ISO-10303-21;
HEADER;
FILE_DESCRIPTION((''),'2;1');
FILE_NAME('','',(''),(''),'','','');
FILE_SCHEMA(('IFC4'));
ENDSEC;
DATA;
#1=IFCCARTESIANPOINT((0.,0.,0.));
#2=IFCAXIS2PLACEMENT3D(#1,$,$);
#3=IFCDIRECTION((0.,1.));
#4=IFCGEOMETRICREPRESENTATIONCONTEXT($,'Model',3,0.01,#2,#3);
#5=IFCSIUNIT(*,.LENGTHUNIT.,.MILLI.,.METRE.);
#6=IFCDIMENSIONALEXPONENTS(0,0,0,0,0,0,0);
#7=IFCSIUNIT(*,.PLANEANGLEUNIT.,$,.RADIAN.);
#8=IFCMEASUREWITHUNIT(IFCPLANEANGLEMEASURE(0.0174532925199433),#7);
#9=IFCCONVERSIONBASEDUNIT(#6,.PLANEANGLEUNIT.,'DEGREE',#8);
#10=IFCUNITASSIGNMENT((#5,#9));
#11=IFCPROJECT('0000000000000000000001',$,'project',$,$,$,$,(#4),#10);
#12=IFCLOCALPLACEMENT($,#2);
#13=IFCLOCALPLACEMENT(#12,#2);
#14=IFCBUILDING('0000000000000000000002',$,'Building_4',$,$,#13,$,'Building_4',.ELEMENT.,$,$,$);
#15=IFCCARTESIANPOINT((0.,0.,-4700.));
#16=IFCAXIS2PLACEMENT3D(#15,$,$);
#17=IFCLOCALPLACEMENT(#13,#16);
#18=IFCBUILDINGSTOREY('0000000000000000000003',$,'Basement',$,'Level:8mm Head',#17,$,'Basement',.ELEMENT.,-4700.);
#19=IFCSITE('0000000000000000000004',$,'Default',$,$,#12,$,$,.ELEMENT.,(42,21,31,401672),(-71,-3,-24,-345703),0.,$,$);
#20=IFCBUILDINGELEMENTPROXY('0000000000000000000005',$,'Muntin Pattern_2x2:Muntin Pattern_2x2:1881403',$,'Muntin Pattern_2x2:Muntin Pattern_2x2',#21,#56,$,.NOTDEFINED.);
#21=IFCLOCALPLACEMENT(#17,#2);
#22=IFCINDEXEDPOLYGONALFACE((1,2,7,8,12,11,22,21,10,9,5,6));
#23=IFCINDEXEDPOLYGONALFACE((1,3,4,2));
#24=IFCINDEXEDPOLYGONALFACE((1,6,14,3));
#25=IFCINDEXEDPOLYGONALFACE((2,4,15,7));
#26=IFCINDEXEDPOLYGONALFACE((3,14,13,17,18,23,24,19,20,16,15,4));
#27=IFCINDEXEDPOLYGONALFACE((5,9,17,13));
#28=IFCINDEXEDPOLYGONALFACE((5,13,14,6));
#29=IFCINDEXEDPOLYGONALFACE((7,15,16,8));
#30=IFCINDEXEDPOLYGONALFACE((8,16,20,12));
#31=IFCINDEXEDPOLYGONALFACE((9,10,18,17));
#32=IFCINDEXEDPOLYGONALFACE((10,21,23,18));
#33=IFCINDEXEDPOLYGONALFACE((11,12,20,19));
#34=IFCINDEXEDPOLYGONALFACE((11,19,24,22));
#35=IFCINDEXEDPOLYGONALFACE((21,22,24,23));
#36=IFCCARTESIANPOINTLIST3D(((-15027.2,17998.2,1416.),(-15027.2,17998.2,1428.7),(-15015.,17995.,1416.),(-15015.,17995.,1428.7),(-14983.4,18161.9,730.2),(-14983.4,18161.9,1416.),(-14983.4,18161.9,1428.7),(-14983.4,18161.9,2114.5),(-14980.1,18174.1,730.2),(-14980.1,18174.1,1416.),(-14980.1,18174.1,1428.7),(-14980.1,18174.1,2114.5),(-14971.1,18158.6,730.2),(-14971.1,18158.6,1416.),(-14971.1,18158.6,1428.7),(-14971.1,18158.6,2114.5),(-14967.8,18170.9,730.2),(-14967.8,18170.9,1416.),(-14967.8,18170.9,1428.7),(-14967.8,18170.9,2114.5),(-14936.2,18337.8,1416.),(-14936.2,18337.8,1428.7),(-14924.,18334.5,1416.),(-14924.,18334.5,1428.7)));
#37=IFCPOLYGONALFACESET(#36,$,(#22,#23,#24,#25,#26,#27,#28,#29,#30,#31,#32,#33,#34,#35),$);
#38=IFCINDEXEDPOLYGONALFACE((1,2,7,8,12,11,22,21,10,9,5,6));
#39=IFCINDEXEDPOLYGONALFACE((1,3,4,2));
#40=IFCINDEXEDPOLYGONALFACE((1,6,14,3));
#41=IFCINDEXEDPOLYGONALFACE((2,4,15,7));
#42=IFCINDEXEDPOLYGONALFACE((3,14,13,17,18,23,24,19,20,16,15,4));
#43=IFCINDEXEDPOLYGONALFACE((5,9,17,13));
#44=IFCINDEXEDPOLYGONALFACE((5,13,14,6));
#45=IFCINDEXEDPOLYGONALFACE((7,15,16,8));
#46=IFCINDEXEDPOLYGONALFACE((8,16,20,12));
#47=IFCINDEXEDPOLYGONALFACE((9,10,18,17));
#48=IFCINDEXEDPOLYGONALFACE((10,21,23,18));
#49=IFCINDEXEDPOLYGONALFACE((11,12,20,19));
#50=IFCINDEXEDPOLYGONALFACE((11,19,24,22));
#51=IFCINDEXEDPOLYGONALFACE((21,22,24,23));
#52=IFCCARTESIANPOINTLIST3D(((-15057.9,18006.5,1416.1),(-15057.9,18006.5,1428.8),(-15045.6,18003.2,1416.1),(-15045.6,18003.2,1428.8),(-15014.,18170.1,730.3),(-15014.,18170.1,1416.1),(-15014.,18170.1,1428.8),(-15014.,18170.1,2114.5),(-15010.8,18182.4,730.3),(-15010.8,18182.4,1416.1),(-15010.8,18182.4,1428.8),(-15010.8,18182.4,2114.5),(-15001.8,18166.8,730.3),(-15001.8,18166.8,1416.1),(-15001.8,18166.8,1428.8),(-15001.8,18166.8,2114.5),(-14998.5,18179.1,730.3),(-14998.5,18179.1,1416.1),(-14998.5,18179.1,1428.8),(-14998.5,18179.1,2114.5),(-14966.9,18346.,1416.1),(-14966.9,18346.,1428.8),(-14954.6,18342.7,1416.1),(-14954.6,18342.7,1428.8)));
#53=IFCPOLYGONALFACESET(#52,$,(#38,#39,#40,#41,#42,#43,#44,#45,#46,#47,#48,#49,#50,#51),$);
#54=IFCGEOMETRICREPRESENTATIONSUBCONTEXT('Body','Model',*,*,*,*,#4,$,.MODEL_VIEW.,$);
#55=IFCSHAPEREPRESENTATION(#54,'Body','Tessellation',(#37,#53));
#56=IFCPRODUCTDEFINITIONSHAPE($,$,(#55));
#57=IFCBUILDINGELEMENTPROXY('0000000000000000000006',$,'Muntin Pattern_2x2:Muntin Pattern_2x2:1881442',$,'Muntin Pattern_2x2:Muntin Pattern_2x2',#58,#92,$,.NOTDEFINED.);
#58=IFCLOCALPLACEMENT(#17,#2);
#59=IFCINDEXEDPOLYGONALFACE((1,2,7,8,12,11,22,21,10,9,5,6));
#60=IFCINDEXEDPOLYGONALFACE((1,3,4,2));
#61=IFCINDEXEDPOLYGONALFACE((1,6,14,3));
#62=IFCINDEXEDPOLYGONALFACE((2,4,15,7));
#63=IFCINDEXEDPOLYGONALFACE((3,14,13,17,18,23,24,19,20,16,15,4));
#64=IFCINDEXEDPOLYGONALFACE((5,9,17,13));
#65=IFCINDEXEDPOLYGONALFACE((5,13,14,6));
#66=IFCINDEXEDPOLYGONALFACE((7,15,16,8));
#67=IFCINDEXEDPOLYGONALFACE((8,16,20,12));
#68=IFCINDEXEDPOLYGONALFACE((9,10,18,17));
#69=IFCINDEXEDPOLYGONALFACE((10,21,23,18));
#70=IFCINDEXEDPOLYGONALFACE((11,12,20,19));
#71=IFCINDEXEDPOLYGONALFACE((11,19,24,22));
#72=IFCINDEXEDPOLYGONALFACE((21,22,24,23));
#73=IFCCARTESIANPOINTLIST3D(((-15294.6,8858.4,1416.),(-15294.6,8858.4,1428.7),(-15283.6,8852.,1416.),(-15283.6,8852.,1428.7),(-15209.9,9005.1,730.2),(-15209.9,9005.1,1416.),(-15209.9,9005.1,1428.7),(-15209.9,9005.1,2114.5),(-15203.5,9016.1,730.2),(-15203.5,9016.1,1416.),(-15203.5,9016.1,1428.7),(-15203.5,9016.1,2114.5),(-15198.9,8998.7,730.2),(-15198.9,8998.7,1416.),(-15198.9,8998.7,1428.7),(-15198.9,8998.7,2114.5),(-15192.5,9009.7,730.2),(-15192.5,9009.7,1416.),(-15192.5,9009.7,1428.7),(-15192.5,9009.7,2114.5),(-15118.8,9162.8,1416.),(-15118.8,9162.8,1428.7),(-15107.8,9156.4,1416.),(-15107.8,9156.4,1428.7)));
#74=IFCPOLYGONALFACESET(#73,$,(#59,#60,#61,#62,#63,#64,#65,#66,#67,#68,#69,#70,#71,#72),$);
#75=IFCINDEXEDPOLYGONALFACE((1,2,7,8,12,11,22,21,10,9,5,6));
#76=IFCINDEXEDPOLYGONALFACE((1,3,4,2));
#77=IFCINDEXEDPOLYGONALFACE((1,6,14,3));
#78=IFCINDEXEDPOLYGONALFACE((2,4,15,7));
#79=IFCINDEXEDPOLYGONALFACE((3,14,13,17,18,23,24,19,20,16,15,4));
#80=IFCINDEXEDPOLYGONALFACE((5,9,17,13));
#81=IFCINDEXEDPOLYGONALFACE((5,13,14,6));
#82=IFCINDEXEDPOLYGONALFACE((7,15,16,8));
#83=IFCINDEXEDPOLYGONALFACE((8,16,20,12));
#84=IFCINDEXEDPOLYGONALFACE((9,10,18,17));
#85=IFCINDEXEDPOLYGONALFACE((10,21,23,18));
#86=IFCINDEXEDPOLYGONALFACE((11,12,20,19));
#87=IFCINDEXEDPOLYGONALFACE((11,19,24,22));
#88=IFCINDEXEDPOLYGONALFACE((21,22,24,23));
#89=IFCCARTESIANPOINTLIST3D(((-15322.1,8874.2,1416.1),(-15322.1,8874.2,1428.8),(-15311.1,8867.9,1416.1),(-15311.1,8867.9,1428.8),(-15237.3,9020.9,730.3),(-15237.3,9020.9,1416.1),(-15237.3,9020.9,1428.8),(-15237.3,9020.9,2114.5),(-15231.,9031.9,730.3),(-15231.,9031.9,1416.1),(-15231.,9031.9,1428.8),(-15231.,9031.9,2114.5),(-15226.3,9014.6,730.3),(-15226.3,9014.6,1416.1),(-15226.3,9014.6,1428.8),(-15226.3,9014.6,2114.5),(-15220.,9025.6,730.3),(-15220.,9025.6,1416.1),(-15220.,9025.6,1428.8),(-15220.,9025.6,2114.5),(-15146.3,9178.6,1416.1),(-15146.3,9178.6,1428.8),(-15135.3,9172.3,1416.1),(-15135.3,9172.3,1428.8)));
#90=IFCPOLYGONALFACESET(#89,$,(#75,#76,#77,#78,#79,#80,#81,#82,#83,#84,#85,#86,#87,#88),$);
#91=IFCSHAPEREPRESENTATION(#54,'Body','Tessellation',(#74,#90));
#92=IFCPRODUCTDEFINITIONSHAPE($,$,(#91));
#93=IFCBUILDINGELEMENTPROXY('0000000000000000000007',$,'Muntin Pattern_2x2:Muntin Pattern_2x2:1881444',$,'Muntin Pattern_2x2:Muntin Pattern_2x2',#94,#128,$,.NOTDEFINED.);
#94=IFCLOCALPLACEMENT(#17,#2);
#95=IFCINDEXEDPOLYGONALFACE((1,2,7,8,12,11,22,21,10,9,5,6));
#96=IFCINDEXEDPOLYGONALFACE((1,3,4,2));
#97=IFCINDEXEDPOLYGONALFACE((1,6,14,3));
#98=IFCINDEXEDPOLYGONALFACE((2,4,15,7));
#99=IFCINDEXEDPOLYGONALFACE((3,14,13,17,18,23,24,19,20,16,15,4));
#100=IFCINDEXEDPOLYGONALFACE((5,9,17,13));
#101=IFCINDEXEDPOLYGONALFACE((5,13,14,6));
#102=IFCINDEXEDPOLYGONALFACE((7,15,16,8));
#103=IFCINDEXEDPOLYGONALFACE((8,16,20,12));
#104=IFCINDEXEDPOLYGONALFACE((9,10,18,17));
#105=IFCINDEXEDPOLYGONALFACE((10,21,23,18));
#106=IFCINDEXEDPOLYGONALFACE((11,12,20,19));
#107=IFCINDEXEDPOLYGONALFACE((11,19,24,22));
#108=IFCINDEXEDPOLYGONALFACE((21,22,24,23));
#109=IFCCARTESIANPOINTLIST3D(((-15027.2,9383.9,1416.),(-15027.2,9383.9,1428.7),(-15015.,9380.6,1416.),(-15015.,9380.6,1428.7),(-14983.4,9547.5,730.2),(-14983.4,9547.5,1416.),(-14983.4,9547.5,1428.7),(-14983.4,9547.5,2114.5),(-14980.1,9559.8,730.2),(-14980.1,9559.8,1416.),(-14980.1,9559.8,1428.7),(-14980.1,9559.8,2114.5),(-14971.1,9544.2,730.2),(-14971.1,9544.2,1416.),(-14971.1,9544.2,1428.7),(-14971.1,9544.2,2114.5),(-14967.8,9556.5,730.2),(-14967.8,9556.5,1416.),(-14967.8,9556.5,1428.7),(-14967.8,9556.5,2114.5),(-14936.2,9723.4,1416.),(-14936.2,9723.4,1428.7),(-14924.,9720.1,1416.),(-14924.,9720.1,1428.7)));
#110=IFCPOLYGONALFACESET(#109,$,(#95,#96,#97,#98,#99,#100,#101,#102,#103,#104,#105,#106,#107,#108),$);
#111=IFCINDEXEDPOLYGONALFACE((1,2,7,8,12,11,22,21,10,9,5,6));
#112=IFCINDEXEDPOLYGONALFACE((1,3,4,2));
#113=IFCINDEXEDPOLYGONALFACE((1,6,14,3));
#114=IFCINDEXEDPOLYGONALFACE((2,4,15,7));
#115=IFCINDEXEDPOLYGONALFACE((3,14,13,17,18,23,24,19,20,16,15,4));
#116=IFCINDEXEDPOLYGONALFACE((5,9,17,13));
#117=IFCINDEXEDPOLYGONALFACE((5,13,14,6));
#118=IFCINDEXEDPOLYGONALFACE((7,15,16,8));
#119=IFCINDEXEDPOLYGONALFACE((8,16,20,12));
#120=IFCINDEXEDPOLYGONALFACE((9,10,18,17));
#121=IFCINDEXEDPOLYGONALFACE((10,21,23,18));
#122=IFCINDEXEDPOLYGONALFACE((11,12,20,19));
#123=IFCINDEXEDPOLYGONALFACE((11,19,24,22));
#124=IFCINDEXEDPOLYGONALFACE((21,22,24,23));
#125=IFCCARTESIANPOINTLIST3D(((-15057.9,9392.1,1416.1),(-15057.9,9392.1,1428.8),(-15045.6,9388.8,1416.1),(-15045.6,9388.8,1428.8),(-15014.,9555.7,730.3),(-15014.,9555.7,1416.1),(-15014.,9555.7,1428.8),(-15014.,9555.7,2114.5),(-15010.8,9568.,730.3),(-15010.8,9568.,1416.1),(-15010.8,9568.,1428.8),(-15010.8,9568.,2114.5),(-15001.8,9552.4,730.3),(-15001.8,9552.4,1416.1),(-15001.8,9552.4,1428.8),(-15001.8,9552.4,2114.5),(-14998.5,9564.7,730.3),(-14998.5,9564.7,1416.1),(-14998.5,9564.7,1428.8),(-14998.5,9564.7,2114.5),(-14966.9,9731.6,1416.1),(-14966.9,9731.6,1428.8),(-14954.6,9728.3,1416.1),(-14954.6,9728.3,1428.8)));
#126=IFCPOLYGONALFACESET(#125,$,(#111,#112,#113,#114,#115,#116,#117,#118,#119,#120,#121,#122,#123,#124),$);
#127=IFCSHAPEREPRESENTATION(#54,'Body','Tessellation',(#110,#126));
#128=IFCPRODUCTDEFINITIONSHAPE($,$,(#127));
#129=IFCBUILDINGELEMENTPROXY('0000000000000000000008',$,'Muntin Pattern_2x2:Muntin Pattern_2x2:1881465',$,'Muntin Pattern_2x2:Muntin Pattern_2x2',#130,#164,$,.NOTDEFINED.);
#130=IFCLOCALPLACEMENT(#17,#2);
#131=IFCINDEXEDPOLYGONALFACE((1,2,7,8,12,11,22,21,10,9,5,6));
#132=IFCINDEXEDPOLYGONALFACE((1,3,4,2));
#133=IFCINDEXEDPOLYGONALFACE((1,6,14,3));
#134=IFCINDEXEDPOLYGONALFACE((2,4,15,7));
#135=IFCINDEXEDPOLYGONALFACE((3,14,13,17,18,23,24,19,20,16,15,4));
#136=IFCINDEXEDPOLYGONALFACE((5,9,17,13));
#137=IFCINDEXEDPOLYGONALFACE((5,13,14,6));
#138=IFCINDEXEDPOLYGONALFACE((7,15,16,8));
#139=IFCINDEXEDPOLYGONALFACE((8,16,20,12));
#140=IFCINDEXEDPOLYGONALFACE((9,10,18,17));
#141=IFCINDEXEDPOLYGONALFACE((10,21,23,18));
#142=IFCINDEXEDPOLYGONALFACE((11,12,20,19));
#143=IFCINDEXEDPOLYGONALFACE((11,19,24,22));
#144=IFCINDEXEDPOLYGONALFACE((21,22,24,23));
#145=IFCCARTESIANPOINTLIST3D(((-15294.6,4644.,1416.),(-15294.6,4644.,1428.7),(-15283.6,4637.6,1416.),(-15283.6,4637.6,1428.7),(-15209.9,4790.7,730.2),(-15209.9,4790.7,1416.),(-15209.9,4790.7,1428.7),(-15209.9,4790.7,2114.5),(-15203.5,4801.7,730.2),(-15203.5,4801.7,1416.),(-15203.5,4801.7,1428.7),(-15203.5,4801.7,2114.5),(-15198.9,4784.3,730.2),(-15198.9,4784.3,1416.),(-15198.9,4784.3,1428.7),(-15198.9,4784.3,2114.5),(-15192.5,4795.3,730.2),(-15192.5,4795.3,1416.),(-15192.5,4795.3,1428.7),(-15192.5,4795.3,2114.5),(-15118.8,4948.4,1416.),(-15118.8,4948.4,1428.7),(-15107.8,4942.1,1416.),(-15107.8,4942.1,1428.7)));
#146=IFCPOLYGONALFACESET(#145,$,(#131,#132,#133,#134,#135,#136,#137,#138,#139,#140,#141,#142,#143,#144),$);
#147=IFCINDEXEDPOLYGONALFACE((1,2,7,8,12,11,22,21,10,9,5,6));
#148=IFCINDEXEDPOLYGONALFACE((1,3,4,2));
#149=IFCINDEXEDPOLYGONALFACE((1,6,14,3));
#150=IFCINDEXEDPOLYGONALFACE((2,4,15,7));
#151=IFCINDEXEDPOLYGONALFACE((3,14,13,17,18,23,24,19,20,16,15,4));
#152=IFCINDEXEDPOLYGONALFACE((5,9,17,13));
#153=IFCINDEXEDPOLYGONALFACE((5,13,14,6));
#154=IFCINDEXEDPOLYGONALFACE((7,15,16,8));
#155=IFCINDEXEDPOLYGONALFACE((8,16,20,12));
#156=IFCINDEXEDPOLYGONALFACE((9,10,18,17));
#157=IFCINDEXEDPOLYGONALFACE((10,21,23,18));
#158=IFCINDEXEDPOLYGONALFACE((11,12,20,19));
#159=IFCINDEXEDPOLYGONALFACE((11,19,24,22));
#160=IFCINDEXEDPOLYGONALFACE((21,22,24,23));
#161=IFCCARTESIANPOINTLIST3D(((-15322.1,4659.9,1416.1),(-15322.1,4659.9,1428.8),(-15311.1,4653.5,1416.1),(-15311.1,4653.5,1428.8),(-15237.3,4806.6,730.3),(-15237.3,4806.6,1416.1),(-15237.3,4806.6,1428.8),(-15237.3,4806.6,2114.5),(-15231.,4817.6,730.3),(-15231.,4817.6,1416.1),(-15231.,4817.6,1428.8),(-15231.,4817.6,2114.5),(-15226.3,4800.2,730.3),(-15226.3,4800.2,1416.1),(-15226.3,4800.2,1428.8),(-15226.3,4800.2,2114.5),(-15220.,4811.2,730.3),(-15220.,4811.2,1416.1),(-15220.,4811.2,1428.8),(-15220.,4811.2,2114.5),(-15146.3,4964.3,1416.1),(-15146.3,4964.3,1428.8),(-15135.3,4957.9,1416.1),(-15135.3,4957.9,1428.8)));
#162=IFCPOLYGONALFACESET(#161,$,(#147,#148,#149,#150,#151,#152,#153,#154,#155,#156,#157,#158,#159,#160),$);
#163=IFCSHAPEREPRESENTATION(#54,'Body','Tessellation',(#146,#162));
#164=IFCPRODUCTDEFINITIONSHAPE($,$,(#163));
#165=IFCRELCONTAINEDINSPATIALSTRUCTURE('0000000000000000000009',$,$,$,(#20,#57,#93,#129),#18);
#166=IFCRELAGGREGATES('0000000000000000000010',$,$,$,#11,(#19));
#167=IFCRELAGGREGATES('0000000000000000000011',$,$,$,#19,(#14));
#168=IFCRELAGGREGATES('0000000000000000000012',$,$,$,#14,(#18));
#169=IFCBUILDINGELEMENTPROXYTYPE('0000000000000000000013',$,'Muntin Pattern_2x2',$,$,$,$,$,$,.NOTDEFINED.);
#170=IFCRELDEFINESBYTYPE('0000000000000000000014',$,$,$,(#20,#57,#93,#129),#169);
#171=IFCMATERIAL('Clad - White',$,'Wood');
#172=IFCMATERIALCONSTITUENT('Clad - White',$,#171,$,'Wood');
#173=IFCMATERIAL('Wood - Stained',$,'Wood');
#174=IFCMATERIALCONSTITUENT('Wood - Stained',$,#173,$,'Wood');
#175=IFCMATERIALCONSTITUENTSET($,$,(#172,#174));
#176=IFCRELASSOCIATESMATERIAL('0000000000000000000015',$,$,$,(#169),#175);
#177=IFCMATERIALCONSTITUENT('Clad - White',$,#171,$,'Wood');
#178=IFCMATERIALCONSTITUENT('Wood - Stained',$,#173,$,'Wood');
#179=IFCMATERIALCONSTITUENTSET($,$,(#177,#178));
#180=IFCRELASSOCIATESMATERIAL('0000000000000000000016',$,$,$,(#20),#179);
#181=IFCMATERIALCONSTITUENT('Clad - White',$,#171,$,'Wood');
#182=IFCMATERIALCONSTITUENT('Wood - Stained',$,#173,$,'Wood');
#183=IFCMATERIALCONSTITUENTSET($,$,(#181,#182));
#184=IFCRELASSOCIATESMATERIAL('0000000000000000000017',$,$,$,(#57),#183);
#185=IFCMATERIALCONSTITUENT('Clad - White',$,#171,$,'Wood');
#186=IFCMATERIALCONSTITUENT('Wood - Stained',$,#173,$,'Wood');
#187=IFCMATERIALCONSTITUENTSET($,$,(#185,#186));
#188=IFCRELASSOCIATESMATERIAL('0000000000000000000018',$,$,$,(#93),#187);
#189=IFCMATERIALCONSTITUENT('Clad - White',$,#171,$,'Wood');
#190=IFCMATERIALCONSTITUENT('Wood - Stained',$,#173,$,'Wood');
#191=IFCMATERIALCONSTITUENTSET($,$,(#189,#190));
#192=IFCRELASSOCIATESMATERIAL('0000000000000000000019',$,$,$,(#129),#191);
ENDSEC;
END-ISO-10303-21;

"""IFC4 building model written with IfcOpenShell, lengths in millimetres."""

from ifc_helpers import new_model, entity, si_unit, converted_unit, direction, frame, origin, place, context, subcontext, project, spatial, indexed_curve, outline, extrude, source, transform, mapped, material, constituent, constituent_set, type_object, type_shapes, element, save


model = new_model("IFC4")

# Units and contexts
model_context = context("Model", 3, precision=0.01, world=origin(), true_north=direction((0.0, 1.0)))
body_context = subcontext(model_context, "Body", "Model", "MODEL_VIEW")
ifc_project = project(units=[si_unit("LENGTHUNIT", "METRE", prefix="MILLI"), converted_unit("PLANEANGLEUNIT", "DEGREE", entity("IfcPlaneAngleMeasure", 0.0174532925199433), si_unit("PLANEANGLEUNIT", "RADIAN"), dimensions=[0, 0, 0, 0, 0, 0, 0])], contexts=[model_context])

# Site, building, storey
site_placement = place(None, origin())
site = spatial("IfcSite", under=ifc_project, at=site_placement, Name="Default", CompositionType="ELEMENT", RefLatitude=(42, 21, 31, 401672), RefLongitude=(-71, -3, -24, -345703), RefElevation=0.0)
building_placement = place(site_placement, origin())
building = spatial("IfcBuilding", under=site, at=building_placement, Name="Building_4", LongName="Building_4", CompositionType="ELEMENT")
storey_placement = place(building_placement, frame((0.0, 0.0, -4700.0)))
storey = spatial("IfcBuildingStorey", under=building, at=storey_placement, Name="Basement", ObjectType="Level:8mm Head", LongName="Basement", CompositionType="ELEMENT", Elevation=-4700.0)

# Building element proxies
ifc_material_1 = material(Name="Clad - White", Category="Wood")
ifc_material_2 = material(Name="Wood - Stained", Category="Wood")
ifc_constituent_1 = constituent(ifc_material_1, Name="Clad - White", Category="Wood")
ifc_constituent_2 = constituent(ifc_material_2, Name="Wood - Stained", Category="Wood")
ifc_constituent_set_1 = constituent_set(constituents=[ifc_constituent_1, ifc_constituent_2])
building_element_proxy_type_1 = type_object("IfcBuildingElementProxyType", Name="Muntin Pattern_2x2", PredefinedType="NOTDEFINED", material=ifc_constituent_set_1)
shared_shape_1 = source(origin(), body_context, "Body", "SweptSolid", [
    extrude(outline(indexed_curve([(6.4, -6.4), (692.1, -6.4), (692.1, 6.3), (6.4, 6.3), (6.4, 175.8), (-6.3, 175.8), (-6.3, 6.3), (-692.2, 6.3), (-692.2, -6.4), (-6.3, -6.4), (-6.3, -175.8), (6.4, -175.8), (6.4, -6.4)], self_intersect=False)), frame((0.0, -22.2, 692.1), z_axis=(0.0, 1.0, 0.0), x_axis=(0.0, 0.0, 1.0)), (0.0, 0.0, 1.0), 12.7),
    extrude(outline(indexed_curve([(6.4, -6.4), (692.1, -6.4), (692.1, 6.3), (6.4, 6.3), (6.4, 175.8), (-6.3, 175.8), (-6.3, 6.3), (-692.1, 6.3), (-692.1, -6.4), (-6.3, -6.4), (-6.3, -175.8), (6.4, -175.8), (6.4, -6.4)], self_intersect=False)), frame((0.0, 9.5, 692.1), z_axis=(0.0, 1.0, 0.0), x_axis=(0.0, 0.0, 1.0)), (0.0, 0.0, 1.0), 12.7),
])
type_shapes(building_element_proxy_type_1, [shared_shape_1])
ifc_constituent_3 = constituent(ifc_material_1, Name="Clad - White", Category="Wood")
ifc_constituent_4 = constituent(ifc_material_2, Name="Wood - Stained", Category="Wood")
ifc_constituent_set_2 = constituent_set(constituents=[ifc_constituent_3, ifc_constituent_4])
proxy_1_placement = place(storey_placement, frame((-14990.9, 18170.5, 730.3), z_axis=(0.0, 0.0, 1.0), x_axis=(0.258819, 0.965926, 0.0)))
element("IfcBuildingElementProxy", 1, at=proxy_1_placement, inside=storey, type_object=building_element_proxy_type_1, material=ifc_constituent_set_2, Name="Muntin Pattern_2x2:Muntin Pattern_2x2:1881403", ObjectType="Muntin Pattern_2x2:Muntin Pattern_2x2", PredefinedType="NOTDEFINED", context=body_context, shape_type="MappedRepresentation", body=[
    mapped(shared_shape_1, transform((0.0, 0.0, 0.0), scale=1.0)),
])
ifc_constituent_5 = constituent(ifc_material_1, Name="Clad - White", Category="Wood")
ifc_constituent_6 = constituent(ifc_material_2, Name="Wood - Stained", Category="Wood")
ifc_constituent_set_3 = constituent_set(constituents=[ifc_constituent_5, ifc_constituent_6])
proxy_2_placement = place(storey_placement, frame((-15214.9, 9015.3, 730.3), z_axis=(0.0, 0.0, 1.0), x_axis=(0.5, 0.866025, 0.0)))
element("IfcBuildingElementProxy", 2, at=proxy_2_placement, inside=storey, type_object=building_element_proxy_type_1, material=ifc_constituent_set_3, Name="Muntin Pattern_2x2:Muntin Pattern_2x2:1881442", ObjectType="Muntin Pattern_2x2:Muntin Pattern_2x2", PredefinedType="NOTDEFINED", context=body_context, shape_type="MappedRepresentation", body=[
    mapped(shared_shape_1, transform((0.0, 0.0, 0.0), scale=1.0)),
])
ifc_constituent_7 = constituent(ifc_material_1, Name="Clad - White", Category="Wood")
ifc_constituent_8 = constituent(ifc_material_2, Name="Wood - Stained", Category="Wood")
ifc_constituent_set_4 = constituent_set(constituents=[ifc_constituent_7, ifc_constituent_8])
proxy_3_placement = place(storey_placement, frame((-14990.9, 9556.1, 730.3), z_axis=(0.0, 0.0, 1.0), x_axis=(0.258819, 0.965926, 0.0)))
element("IfcBuildingElementProxy", 3, at=proxy_3_placement, inside=storey, type_object=building_element_proxy_type_1, material=ifc_constituent_set_4, Name="Muntin Pattern_2x2:Muntin Pattern_2x2:1881444", ObjectType="Muntin Pattern_2x2:Muntin Pattern_2x2", PredefinedType="NOTDEFINED", context=body_context, shape_type="MappedRepresentation", body=[
    mapped(shared_shape_1, transform((0.0, 0.0, 0.0), scale=1.0)),
])
ifc_constituent_9 = constituent(ifc_material_1, Name="Clad - White", Category="Wood")
ifc_constituent_10 = constituent(ifc_material_2, Name="Wood - Stained", Category="Wood")
ifc_constituent_set_5 = constituent_set(constituents=[ifc_constituent_9, ifc_constituent_10])
proxy_4_placement = place(storey_placement, frame((-15214.9, 4801.0, 730.3), z_axis=(0.0, 0.0, 1.0), x_axis=(0.5, 0.866025, 0.0)))
element("IfcBuildingElementProxy", 4, at=proxy_4_placement, inside=storey, type_object=building_element_proxy_type_1, material=ifc_constituent_set_5, Name="Muntin Pattern_2x2:Muntin Pattern_2x2:1881465", ObjectType="Muntin Pattern_2x2:Muntin Pattern_2x2", PredefinedType="NOTDEFINED", context=body_context, shape_type="MappedRepresentation", body=[
    mapped(shared_shape_1, transform((0.0, 0.0, 0.0), scale=1.0)),
])

save(model, "model.ifc")
